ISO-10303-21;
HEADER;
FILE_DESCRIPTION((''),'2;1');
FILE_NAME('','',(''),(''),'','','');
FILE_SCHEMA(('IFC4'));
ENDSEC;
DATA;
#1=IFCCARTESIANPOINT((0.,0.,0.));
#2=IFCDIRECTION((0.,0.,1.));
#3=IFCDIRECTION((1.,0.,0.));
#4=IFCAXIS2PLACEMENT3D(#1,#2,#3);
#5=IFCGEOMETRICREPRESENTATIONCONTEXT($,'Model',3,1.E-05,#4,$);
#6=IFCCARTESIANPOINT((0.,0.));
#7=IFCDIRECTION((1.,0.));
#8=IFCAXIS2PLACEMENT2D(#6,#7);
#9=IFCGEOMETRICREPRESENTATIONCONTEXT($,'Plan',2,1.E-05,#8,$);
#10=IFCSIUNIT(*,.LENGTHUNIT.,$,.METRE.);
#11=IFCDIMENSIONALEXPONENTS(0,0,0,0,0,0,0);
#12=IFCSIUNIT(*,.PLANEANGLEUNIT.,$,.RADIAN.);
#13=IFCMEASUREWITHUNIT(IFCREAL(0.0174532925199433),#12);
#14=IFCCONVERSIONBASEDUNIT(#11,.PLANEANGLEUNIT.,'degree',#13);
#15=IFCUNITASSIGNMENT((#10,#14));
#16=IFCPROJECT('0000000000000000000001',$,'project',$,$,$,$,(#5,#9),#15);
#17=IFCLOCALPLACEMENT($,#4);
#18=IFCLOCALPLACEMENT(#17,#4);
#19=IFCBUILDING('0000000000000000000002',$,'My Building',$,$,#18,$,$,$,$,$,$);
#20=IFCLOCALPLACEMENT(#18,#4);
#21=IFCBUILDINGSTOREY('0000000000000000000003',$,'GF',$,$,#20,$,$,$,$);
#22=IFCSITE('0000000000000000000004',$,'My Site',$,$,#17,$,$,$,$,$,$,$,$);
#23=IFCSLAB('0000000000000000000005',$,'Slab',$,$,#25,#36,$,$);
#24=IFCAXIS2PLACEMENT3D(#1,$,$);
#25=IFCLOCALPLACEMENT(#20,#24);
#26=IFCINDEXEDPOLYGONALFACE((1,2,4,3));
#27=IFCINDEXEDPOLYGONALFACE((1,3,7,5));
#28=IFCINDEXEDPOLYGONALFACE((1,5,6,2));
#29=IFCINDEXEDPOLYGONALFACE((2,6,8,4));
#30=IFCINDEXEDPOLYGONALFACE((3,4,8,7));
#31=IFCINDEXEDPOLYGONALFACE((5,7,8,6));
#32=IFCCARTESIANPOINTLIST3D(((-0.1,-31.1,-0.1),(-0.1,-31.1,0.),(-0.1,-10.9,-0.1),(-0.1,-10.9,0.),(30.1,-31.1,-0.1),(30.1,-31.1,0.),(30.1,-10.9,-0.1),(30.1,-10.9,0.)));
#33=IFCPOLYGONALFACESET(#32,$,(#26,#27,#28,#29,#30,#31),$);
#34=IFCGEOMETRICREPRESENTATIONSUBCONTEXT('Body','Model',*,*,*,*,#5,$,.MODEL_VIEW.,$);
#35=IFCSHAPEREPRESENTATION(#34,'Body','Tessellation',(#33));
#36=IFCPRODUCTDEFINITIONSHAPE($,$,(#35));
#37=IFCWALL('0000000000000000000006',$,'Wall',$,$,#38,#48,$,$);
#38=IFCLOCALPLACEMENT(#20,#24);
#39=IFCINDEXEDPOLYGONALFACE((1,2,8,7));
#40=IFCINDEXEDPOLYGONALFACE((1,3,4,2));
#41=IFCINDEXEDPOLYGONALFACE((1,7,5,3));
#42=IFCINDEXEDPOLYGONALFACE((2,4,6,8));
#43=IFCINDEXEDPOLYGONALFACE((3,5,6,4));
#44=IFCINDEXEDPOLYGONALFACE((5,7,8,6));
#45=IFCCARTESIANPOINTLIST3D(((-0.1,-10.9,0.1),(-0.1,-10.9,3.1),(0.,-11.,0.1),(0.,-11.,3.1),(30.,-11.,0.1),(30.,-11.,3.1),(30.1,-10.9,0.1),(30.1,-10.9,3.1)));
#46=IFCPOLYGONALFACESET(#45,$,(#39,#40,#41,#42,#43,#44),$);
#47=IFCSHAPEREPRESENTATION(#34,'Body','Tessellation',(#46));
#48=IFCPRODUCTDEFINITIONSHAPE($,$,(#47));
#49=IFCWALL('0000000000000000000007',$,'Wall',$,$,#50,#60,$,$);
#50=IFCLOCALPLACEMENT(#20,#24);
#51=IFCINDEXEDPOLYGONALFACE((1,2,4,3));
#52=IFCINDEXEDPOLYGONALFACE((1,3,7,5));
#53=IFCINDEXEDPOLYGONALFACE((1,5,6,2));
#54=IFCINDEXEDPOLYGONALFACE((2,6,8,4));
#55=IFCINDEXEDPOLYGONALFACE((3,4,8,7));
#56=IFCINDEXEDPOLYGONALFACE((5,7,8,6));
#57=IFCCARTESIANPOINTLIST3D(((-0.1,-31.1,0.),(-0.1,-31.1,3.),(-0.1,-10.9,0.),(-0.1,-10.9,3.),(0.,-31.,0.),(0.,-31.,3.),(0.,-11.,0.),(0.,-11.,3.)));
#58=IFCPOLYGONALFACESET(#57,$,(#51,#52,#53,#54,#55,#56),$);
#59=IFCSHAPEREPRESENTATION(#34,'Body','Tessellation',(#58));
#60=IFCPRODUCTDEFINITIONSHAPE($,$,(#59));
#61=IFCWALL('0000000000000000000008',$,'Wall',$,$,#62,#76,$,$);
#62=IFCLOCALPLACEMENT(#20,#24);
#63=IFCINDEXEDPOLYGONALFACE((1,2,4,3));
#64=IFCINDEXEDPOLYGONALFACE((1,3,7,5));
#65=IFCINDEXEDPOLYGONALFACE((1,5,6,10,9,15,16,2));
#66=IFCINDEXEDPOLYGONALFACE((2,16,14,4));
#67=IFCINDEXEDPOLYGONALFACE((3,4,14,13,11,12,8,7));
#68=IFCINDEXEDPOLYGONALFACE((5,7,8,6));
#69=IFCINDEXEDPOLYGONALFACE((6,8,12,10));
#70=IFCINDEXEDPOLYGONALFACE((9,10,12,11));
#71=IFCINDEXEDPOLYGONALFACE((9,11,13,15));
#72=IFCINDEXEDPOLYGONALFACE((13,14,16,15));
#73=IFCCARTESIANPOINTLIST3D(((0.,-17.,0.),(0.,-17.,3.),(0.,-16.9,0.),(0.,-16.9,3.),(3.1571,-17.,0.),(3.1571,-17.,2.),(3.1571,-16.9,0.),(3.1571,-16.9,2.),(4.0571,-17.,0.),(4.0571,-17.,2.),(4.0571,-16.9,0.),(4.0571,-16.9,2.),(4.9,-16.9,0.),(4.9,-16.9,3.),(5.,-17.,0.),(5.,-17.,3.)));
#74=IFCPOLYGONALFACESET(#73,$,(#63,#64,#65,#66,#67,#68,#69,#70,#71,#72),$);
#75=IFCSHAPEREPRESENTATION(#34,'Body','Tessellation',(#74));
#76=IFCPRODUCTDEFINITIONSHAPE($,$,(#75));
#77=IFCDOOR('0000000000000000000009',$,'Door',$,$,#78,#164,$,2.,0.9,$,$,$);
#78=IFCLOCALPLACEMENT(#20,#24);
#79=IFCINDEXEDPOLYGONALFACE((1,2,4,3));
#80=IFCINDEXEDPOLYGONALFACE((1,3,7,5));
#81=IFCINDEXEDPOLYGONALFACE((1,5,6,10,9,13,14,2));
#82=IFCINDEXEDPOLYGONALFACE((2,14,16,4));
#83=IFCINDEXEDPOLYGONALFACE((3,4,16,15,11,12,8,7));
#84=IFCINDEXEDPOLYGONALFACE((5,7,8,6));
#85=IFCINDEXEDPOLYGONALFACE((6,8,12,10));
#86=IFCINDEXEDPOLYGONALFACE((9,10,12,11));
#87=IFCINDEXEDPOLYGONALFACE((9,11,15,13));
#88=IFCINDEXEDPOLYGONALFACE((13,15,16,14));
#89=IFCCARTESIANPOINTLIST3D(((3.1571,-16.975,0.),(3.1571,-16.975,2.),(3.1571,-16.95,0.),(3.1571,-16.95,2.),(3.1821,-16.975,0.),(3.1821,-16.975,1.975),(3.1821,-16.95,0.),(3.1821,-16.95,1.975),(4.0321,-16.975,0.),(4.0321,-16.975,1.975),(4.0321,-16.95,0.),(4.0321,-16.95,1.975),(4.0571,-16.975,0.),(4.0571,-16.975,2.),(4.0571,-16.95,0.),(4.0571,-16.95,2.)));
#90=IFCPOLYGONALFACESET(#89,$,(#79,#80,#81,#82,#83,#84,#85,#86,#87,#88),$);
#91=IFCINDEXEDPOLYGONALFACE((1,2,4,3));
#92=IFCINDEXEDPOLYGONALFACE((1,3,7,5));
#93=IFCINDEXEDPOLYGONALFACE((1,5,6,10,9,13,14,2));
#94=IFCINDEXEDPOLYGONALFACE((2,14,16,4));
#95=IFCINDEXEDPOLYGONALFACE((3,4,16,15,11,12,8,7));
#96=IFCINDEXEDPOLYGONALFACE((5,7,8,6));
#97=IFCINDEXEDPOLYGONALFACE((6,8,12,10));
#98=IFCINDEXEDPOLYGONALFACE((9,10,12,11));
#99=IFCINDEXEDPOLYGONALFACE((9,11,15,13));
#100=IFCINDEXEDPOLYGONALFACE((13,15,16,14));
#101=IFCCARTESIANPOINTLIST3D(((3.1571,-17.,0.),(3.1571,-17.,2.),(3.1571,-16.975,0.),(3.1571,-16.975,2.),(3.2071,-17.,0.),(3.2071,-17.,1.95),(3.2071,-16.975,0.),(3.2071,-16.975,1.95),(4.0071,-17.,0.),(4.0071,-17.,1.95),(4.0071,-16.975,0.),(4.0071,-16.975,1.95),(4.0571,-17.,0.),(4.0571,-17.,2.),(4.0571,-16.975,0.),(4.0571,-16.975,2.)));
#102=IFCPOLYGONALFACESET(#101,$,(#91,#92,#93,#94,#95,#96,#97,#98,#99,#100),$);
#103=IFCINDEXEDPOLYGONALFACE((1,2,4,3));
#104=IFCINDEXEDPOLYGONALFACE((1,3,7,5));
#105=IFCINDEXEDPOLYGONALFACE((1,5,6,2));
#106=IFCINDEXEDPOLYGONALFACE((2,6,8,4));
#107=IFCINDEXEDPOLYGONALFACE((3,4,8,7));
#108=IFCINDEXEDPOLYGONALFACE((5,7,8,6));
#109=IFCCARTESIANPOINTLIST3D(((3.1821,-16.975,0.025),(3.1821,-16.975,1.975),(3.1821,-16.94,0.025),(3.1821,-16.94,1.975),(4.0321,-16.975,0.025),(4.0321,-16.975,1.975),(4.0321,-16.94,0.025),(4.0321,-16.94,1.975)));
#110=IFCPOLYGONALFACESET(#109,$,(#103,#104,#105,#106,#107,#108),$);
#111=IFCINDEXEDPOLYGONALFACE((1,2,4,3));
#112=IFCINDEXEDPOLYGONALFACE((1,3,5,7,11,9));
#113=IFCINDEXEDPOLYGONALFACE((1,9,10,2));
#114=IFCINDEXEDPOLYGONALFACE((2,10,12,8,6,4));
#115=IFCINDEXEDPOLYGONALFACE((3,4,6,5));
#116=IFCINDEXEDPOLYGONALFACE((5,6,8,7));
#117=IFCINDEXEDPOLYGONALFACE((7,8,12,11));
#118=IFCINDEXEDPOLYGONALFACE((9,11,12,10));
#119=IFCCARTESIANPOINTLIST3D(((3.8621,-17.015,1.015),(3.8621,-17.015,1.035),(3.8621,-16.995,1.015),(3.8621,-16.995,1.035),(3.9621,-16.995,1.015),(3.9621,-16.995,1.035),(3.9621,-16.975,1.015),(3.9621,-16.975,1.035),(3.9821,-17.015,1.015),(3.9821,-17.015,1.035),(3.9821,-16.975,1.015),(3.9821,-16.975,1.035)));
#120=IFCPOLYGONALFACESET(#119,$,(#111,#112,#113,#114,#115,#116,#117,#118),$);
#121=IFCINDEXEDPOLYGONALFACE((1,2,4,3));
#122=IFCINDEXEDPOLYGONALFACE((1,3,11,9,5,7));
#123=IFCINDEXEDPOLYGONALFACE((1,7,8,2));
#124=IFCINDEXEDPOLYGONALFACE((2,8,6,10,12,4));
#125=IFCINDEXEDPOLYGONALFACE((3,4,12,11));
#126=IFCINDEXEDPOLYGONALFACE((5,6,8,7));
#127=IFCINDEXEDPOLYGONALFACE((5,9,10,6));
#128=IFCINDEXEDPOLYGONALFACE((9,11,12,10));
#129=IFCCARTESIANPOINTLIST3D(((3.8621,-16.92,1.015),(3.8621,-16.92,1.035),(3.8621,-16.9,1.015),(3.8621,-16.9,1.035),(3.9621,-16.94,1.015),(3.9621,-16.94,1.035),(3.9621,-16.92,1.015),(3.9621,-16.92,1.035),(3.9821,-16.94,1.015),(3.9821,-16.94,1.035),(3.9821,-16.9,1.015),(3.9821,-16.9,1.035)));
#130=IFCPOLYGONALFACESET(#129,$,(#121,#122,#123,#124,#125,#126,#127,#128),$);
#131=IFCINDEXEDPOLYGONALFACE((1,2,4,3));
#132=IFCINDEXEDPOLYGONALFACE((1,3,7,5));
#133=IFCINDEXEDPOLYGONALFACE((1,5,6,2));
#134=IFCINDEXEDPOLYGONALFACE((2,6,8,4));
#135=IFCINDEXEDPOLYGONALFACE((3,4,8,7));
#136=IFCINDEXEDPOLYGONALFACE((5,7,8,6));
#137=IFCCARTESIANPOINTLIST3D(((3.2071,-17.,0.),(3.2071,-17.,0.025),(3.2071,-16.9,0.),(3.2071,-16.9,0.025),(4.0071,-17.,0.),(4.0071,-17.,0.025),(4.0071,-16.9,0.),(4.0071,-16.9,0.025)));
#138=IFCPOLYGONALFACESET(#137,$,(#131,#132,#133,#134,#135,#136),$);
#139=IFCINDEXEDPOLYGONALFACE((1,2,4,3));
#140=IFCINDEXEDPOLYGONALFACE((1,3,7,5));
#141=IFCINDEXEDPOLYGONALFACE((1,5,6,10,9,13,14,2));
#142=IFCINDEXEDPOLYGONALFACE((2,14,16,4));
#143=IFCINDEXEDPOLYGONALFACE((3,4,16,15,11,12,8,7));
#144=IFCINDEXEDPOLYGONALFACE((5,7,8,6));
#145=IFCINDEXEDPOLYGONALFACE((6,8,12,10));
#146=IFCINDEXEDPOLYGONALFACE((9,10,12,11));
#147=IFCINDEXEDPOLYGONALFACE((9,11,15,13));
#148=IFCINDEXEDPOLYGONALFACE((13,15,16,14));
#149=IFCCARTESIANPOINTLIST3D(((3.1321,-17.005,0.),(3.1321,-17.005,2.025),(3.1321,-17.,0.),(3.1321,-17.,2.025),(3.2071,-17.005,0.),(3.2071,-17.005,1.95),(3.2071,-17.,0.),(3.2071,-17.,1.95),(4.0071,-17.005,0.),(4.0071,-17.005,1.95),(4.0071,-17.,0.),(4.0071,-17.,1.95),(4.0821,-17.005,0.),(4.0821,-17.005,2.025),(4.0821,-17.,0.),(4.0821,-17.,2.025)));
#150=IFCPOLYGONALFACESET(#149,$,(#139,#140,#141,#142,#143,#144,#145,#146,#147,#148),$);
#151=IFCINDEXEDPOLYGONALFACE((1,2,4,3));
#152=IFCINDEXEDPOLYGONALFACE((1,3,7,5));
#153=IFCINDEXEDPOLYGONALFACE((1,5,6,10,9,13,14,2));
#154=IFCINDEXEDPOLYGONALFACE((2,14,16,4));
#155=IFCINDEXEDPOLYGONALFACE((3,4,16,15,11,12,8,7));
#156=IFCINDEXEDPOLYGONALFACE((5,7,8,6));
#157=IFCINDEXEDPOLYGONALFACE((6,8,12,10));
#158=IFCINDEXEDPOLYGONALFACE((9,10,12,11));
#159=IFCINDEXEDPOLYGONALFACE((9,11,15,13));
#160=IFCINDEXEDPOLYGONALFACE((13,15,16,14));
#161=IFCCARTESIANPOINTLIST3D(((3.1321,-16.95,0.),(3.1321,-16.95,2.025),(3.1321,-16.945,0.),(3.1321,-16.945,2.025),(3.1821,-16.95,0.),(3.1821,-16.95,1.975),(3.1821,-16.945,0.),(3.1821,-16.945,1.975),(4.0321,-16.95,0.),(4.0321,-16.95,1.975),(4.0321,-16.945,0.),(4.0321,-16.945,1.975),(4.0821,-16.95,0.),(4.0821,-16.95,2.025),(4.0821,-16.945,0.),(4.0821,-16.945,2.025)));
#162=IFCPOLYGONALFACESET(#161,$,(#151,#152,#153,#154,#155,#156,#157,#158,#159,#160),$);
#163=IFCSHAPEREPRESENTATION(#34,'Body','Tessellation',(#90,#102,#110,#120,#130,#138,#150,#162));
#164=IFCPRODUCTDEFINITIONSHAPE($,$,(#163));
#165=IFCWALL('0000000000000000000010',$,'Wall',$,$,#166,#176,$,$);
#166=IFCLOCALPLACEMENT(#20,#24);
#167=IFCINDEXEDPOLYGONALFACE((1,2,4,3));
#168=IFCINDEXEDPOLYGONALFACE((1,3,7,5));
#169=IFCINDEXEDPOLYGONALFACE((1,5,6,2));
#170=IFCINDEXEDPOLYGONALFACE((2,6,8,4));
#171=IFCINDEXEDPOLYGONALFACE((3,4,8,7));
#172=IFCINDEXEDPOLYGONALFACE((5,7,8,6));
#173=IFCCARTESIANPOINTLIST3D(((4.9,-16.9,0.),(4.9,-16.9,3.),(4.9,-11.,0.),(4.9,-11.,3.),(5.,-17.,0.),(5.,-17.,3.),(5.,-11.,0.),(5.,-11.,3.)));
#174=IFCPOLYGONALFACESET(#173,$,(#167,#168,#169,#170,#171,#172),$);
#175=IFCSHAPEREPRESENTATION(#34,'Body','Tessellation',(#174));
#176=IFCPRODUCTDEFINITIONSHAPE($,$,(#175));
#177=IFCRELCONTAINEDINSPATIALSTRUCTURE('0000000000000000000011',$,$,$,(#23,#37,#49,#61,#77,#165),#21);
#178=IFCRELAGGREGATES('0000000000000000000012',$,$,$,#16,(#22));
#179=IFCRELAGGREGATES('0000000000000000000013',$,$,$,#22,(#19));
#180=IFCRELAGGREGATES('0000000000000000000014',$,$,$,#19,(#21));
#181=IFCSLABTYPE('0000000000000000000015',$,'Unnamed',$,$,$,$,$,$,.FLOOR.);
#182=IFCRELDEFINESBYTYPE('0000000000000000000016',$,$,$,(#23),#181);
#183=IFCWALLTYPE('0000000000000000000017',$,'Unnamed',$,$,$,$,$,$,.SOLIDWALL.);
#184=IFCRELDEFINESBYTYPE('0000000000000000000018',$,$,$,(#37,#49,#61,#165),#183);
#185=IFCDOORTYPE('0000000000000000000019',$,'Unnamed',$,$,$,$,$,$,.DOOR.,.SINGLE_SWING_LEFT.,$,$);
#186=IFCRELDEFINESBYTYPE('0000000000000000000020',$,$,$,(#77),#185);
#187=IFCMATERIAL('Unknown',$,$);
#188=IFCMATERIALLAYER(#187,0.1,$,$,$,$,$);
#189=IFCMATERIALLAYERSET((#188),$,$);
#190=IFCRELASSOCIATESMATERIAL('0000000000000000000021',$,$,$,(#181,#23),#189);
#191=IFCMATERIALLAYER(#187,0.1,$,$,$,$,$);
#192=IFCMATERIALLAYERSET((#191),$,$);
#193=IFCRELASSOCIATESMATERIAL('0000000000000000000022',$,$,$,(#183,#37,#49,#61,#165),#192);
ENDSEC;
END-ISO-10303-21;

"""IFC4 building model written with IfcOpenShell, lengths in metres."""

from ifc_helpers import new_model, entity, si_unit, converted_unit, frame, origin_with_axes, origin_2d_with_axis, place, context, subcontext, project, spatial, line, indexed_curve, outline, extrude, shape, source, transform, mapped, material, layer, layer_set, layer_usage, type_object, type_shapes, element, fill, save


model = new_model("IFC4")

# Units and contexts
model_context = context("Model", 3, precision=1e-05, world=origin_with_axes())
plan_context = context("Plan", 2, precision=1e-05, world=origin_2d_with_axis())
body_context_1 = subcontext(model_context, "Body", "Model", "MODEL_VIEW")
body_context_2 = subcontext(plan_context, "Body", "Plan", "PLAN_VIEW")
ifc_project = project(units=[si_unit("LENGTHUNIT", "METRE"), converted_unit("PLANEANGLEUNIT", "degree", entity("IfcReal", 0.0174532925199433), si_unit("PLANEANGLEUNIT", "RADIAN"), dimensions=[0, 0, 0, 0, 0, 0, 0])], contexts=[model_context, plan_context])

# Site, building, storey
site_placement = place(None, origin_with_axes())
site = spatial("IfcSite", under=ifc_project, at=site_placement, Name="My Site")
building_placement = place(site_placement, origin_with_axes())
building = spatial("IfcBuilding", under=site, at=building_placement, Name="My Building")
storey_placement = place(building_placement, origin_with_axes())
storey = spatial("IfcBuildingStorey", under=building, at=storey_placement, Name="GF")

# Slab
ifc_material = material(Name="Unknown")
ifc_layer_1 = layer(ifc_material, 0.1)
ifc_layer_set_1 = layer_set([ifc_layer_1])
ifc_layer_usage_1 = layer_usage(ifc_layer_set_1, "AXIS3", "POSITIVE", -0.1)
slab_type = type_object("IfcSlabType", Name="Unnamed", PredefinedType="FLOOR", material=ifc_layer_set_1)
slab_placement = place(storey_placement, frame((-0.1, -10.9, 0.0), z_axis=(0.0, 0.0, 1.0), x_axis=(1.0, 0.0, 0.0)))
element("IfcSlab", 1, at=slab_placement, inside=storey, type_object=slab_type, material=ifc_layer_usage_1, Name="Slab", context=body_context_1, shape_type="SweptSolid", body=[
    extrude(outline(indexed_curve([(0.0, 0.0), (30.2, 0.0), (30.2, -20.2), (0.0, -20.2), (0.0, 0.0)])), frame((0.0, 0.0, -0.1), z_axis=(0.0, 0.0, 1.0), x_axis=(1.0, 0.0, 0.0)), (0.0, 0.0, 1.0), 0.1),
])

# Walls
ifc_layer_2 = layer(ifc_material, 0.1)
ifc_layer_set_2 = layer_set([ifc_layer_2])
ifc_layer_usage_2 = layer_usage(ifc_layer_set_2, "AXIS2", "POSITIVE", 0.0)
wall_type = type_object("IfcWallType", Name="Unnamed", PredefinedType="SOLIDWALL", material=ifc_layer_set_2)
wall_1_placement = place(storey_placement, frame((0.0, -11.0, 0.1), z_axis=(0.0, 0.0, 1.0), x_axis=(1.0, 0.0, 0.0)))
element("IfcWall", 2, at=wall_1_placement, inside=storey, type_object=wall_type, material=ifc_layer_usage_2, Name="Wall", context=body_context_1, shape_type="SweptSolid", body=[
    extrude(outline(indexed_curve([(0.0, 0.0), (-0.1, 0.1), (30.1, 0.1), (30.0, 0.0)], segments=[line(1, 2, 3, 4, 1)])), origin_with_axes(), (0.0, 0.0, 1.0), 3.0),
])
ifc_layer_usage_3 = layer_usage(ifc_layer_set_2, "AXIS2", "POSITIVE", 0.0)
wall_2_placement = place(storey_placement, frame((0.0, -31.0, 0.0), z_axis=(0.0, 0.0, 1.0), x_axis=(0.0, 1.0, 0.0)))
element("IfcWall", 3, at=wall_2_placement, inside=storey, type_object=wall_type, material=ifc_layer_usage_3, Name="Wall", context=body_context_1, shape_type="SweptSolid", body=[
    extrude(outline(indexed_curve([(0.0, 0.0), (-0.1, 0.1), (20.1, 0.1), (20.0, 0.0)], segments=[line(1, 2, 3, 4, 1)])), origin_with_axes(), (0.0, 0.0, 1.0), 3.0),
])

# Wall, opening, door
ifc_layer_usage_4 = layer_usage(ifc_layer_set_2, "AXIS2", "POSITIVE", 0.0)
wall_3_placement = place(storey_placement, frame((0.0, -17.0, 0.0), z_axis=(0.0, 0.0, 1.0), x_axis=(1.0, 0.0, 0.0)))
wall_3 = element("IfcWall", 4, at=wall_3_placement, inside=storey, type_object=wall_type, material=ifc_layer_usage_4, Name="Wall", context=body_context_1, shape_type="SweptSolid", body=[
    extrude(outline(indexed_curve([(0.0, 0.0), (0.0, 0.1), (4.9, 0.1), (5.0, 0.0)], segments=[line(1, 2, 3, 4, 1)])), origin_with_axes(), (0.0, 0.0, 1.0), 3.0),
])
shared_shape_1 = source(origin_with_axes(), body_context_1, "Body", "SweptSolid", [
    extrude(outline(indexed_curve([(0.0, 0.0), (0.9, 0.0), (0.9, 2.0), (0.0, 2.0)], segments=[line(1, 2, 3, 4, 1)])), frame((0.0, -0.6, 0.0), z_axis=(0.0, -1.0, 0.0), x_axis=(1.0, 0.0, 0.0)), (0.0, 0.0, -1.0), 1.2),
])
opening_1_placement = place(wall_3_placement, frame((3.1571, 0.0, 0.0), z_axis=(0.0, 0.0, 1.0), x_axis=(1.0, 0.0, 0.0)))
opening_1 = element("IfcOpeningElement", 5, at=opening_1_placement, cuts=wall_3, PredefinedType="OPENING", context=body_context_1, shape_type="MappedRepresentation", body=[
    mapped(shared_shape_1, transform((0.0, 0.0, 0.0), x_axis=(1.0, 0.0, 0.0), y_axis=(0.0, 1.0, 0.0), z_axis=(0.0, 0.0, 1.0), scale=1.0)),
])
door_type = type_object("IfcDoorType", Name="Unnamed", OperationType="SINGLE_SWING_LEFT", PredefinedType="DOOR")
shared_shape_2 = source(origin_with_axes(), body_context_1, "Body", "SweptSolid", [
    extrude(outline(indexed_curve([(0.0, 0.0), (0.0, 2.0), (0.9, 2.0), (0.9, 0.0), (0.875, 0.0), (0.875, 1.975), (0.025, 1.975), (0.025, 0.0)], segments=[line(1, 2, 3, 4, 5, 6, 7, 8, 1)])), frame((0.0, 0.025, 0.0), z_axis=(0.0, -1.0, 0.0), x_axis=(1.0, 0.0, 0.0)), (0.0, 0.0, -1.0), 0.025),
    extrude(outline(indexed_curve([(0.0, 0.0), (0.0, 2.0), (0.9, 2.0), (0.9, 0.0), (0.85, 0.0), (0.85, 1.95), (0.05, 1.95), (0.05, 0.0)], segments=[line(1, 2, 3, 4, 5, 6, 7, 8, 1)])), frame((0.0, 0.0, 0.0), z_axis=(0.0, -1.0, 0.0), x_axis=(1.0, 0.0, 0.0)), (0.0, 0.0, -1.0), 0.025),
    extrude(outline(indexed_curve([(0.0, 0.0), (0.85, 0.0), (0.85, 0.035), (0.0, 0.035)], segments=[line(1, 2, 3, 4, 1)])), frame((0.025, 0.025, 0.025), z_axis=(0.0, 0.0, 1.0), x_axis=(1.0, 0.0, 0.0)), (0.0, 0.0, 1.0), 1.95),
    extrude(outline(indexed_curve([(0.0, 0.0), (0.0, -0.04), (-0.12, -0.04), (-0.12, -0.02), (-0.02, -0.02), (-0.02, 0.0)], segments=[line(1, 2, 3, 4, 5, 6, 1)])), frame((0.825, 0.025, 1.015), z_axis=(0.0, 0.0, 1.0), x_axis=(1.0, 0.0, 0.0)), (0.0, 0.0, 1.0), 0.02),
    extrude(outline(indexed_curve([(0.0, 0.0), (0.0, 0.04), (-0.12, 0.04), (-0.12, 0.02), (-0.02, 0.02), (-0.02, 0.0)], segments=[line(1, 2, 3, 4, 5, 6, 1)])), frame((0.825, 0.06, 1.015), z_axis=(0.0, 0.0, 1.0), x_axis=(1.0, 0.0, 0.0)), (0.0, 0.0, 1.0), 0.02),
    extrude(outline(indexed_curve([(0.0, 0.0), (0.8, 0.0), (0.8, 0.1), (0.0, 0.1)], segments=[line(1, 2, 3, 4, 1)])), frame((0.05, 0.0, 0.0), z_axis=(0.0, 0.0, 1.0), x_axis=(1.0, 0.0, 0.0)), (0.0, 0.0, 1.0), 0.025),
    extrude(outline(indexed_curve([(0.0, 0.0), (0.0, 2.025), (0.95, 2.025), (0.95, 0.0), (0.875, 0.0), (0.875, 1.95), (0.075, 1.95), (0.075, 0.0)], segments=[line(1, 2, 3, 4, 5, 6, 7, 8, 1)])), frame((-0.025, -0.005, 0.0), z_axis=(0.0, -1.0, 0.0), x_axis=(1.0, 0.0, 0.0)), (0.0, 0.0, -1.0), 0.005),
    extrude(outline(indexed_curve([(0.0, 0.0), (0.0, 2.025), (0.95, 2.025), (0.95, 0.0), (0.9, 0.0), (0.9, 1.975), (0.05, 1.975), (0.05, 0.0)], segments=[line(1, 2, 3, 4, 5, 6, 7, 8, 1)])), frame((-0.025, 0.05, 0.0), z_axis=(0.0, -1.0, 0.0), x_axis=(1.0, 0.0, 0.0)), (0.0, 0.0, -1.0), 0.005),
])
shared_shape_3 = source(origin_with_axes(), body_context_2, "Body", "Curve2D", [
    entity("IfcIndexedPolyCurve", entity("IfcCartesianPointList2D", [[0.0, 0.0], [0.0, 0.05], [0.025, 0.05], [0.025, 0.025], [0.05, 0.025], [0.05, 0.0]]), [entity("IfcLineIndex", [1, 2, 3, 4, 5, 6, 1])]),
    entity("IfcIndexedPolyCurve", entity("IfcCartesianPointList2D", [[0.9, 0.0], [0.9, 0.05], [0.875, 0.05], [0.875, 0.025], [0.85, 0.025], [0.85, 0.0]]), [entity("IfcLineIndex", [1, 2, 3, 4, 5, 6, 1])]),
    entity("IfcTrimmedCurve", entity("IfcEllipse", entity("IfcAxis2Placement2D", entity("IfcCartesianPoint", [0.06, 0.05]), entity("IfcDirection", [1.0, 0.0])), 0.815, 0.85), [entity("IfcCartesianPoint", [0.875, 0.05])], [entity("IfcCartesianPoint", [0.06, 0.9])], True, "CARTESIAN"),
    entity("IfcIndexedPolyCurve", entity("IfcCartesianPointList2D", [[0.025, 0.05], [0.06, 0.05], [0.06, 0.9], [0.025, 0.9]]), [entity("IfcLineIndex", [1, 2, 3, 4, 1])]),
])
type_shapes(door_type, [shared_shape_2, shared_shape_3])
door_1_placement = place(opening_1_placement, origin_with_axes())
door_1 = element("IfcDoor", 6, at=door_1_placement, inside=storey, type_object=door_type, Name="Door", OverallHeight=2.0, OverallWidth=0.9, shapes=[
    shape(body_context_1, "Body", "MappedRepresentation", [mapped(shared_shape_2, transform((0.0, 0.0, 0.0), x_axis=(1.0, 0.0, 0.0), y_axis=(0.0, 1.0, 0.0), z_axis=(0.0, 0.0, 1.0), scale=1.0))]),
    shape(body_context_2, "Body", "MappedRepresentation", [mapped(shared_shape_3, transform((0.0, 0.0, 0.0), x_axis=(1.0, 0.0, 0.0), y_axis=(0.0, 1.0, 0.0), z_axis=(0.0, 0.0, 1.0), scale=1.0))]),
])
fill(opening_1, door_1)

# Wall
ifc_layer_usage_5 = layer_usage(ifc_layer_set_2, "AXIS2", "POSITIVE", 0.0)
wall_4_placement = place(storey_placement, frame((5.0, -17.0, 0.0), z_axis=(0.0, 0.0, 1.0), x_axis=(0.0, 1.0, 0.0)))
element("IfcWall", 7, at=wall_4_placement, inside=storey, type_object=wall_type, material=ifc_layer_usage_5, Name="Wall", context=body_context_1, shape_type="SweptSolid", body=[
    extrude(outline(indexed_curve([(0.0, 0.0), (0.1, 0.1), (6.0, 0.1), (6.0, 0.0)], segments=[line(1, 2, 3, 4, 1)])), origin_with_axes(), (0.0, 0.0, 1.0), 3.0),
])

save(model, "model.ifc")
